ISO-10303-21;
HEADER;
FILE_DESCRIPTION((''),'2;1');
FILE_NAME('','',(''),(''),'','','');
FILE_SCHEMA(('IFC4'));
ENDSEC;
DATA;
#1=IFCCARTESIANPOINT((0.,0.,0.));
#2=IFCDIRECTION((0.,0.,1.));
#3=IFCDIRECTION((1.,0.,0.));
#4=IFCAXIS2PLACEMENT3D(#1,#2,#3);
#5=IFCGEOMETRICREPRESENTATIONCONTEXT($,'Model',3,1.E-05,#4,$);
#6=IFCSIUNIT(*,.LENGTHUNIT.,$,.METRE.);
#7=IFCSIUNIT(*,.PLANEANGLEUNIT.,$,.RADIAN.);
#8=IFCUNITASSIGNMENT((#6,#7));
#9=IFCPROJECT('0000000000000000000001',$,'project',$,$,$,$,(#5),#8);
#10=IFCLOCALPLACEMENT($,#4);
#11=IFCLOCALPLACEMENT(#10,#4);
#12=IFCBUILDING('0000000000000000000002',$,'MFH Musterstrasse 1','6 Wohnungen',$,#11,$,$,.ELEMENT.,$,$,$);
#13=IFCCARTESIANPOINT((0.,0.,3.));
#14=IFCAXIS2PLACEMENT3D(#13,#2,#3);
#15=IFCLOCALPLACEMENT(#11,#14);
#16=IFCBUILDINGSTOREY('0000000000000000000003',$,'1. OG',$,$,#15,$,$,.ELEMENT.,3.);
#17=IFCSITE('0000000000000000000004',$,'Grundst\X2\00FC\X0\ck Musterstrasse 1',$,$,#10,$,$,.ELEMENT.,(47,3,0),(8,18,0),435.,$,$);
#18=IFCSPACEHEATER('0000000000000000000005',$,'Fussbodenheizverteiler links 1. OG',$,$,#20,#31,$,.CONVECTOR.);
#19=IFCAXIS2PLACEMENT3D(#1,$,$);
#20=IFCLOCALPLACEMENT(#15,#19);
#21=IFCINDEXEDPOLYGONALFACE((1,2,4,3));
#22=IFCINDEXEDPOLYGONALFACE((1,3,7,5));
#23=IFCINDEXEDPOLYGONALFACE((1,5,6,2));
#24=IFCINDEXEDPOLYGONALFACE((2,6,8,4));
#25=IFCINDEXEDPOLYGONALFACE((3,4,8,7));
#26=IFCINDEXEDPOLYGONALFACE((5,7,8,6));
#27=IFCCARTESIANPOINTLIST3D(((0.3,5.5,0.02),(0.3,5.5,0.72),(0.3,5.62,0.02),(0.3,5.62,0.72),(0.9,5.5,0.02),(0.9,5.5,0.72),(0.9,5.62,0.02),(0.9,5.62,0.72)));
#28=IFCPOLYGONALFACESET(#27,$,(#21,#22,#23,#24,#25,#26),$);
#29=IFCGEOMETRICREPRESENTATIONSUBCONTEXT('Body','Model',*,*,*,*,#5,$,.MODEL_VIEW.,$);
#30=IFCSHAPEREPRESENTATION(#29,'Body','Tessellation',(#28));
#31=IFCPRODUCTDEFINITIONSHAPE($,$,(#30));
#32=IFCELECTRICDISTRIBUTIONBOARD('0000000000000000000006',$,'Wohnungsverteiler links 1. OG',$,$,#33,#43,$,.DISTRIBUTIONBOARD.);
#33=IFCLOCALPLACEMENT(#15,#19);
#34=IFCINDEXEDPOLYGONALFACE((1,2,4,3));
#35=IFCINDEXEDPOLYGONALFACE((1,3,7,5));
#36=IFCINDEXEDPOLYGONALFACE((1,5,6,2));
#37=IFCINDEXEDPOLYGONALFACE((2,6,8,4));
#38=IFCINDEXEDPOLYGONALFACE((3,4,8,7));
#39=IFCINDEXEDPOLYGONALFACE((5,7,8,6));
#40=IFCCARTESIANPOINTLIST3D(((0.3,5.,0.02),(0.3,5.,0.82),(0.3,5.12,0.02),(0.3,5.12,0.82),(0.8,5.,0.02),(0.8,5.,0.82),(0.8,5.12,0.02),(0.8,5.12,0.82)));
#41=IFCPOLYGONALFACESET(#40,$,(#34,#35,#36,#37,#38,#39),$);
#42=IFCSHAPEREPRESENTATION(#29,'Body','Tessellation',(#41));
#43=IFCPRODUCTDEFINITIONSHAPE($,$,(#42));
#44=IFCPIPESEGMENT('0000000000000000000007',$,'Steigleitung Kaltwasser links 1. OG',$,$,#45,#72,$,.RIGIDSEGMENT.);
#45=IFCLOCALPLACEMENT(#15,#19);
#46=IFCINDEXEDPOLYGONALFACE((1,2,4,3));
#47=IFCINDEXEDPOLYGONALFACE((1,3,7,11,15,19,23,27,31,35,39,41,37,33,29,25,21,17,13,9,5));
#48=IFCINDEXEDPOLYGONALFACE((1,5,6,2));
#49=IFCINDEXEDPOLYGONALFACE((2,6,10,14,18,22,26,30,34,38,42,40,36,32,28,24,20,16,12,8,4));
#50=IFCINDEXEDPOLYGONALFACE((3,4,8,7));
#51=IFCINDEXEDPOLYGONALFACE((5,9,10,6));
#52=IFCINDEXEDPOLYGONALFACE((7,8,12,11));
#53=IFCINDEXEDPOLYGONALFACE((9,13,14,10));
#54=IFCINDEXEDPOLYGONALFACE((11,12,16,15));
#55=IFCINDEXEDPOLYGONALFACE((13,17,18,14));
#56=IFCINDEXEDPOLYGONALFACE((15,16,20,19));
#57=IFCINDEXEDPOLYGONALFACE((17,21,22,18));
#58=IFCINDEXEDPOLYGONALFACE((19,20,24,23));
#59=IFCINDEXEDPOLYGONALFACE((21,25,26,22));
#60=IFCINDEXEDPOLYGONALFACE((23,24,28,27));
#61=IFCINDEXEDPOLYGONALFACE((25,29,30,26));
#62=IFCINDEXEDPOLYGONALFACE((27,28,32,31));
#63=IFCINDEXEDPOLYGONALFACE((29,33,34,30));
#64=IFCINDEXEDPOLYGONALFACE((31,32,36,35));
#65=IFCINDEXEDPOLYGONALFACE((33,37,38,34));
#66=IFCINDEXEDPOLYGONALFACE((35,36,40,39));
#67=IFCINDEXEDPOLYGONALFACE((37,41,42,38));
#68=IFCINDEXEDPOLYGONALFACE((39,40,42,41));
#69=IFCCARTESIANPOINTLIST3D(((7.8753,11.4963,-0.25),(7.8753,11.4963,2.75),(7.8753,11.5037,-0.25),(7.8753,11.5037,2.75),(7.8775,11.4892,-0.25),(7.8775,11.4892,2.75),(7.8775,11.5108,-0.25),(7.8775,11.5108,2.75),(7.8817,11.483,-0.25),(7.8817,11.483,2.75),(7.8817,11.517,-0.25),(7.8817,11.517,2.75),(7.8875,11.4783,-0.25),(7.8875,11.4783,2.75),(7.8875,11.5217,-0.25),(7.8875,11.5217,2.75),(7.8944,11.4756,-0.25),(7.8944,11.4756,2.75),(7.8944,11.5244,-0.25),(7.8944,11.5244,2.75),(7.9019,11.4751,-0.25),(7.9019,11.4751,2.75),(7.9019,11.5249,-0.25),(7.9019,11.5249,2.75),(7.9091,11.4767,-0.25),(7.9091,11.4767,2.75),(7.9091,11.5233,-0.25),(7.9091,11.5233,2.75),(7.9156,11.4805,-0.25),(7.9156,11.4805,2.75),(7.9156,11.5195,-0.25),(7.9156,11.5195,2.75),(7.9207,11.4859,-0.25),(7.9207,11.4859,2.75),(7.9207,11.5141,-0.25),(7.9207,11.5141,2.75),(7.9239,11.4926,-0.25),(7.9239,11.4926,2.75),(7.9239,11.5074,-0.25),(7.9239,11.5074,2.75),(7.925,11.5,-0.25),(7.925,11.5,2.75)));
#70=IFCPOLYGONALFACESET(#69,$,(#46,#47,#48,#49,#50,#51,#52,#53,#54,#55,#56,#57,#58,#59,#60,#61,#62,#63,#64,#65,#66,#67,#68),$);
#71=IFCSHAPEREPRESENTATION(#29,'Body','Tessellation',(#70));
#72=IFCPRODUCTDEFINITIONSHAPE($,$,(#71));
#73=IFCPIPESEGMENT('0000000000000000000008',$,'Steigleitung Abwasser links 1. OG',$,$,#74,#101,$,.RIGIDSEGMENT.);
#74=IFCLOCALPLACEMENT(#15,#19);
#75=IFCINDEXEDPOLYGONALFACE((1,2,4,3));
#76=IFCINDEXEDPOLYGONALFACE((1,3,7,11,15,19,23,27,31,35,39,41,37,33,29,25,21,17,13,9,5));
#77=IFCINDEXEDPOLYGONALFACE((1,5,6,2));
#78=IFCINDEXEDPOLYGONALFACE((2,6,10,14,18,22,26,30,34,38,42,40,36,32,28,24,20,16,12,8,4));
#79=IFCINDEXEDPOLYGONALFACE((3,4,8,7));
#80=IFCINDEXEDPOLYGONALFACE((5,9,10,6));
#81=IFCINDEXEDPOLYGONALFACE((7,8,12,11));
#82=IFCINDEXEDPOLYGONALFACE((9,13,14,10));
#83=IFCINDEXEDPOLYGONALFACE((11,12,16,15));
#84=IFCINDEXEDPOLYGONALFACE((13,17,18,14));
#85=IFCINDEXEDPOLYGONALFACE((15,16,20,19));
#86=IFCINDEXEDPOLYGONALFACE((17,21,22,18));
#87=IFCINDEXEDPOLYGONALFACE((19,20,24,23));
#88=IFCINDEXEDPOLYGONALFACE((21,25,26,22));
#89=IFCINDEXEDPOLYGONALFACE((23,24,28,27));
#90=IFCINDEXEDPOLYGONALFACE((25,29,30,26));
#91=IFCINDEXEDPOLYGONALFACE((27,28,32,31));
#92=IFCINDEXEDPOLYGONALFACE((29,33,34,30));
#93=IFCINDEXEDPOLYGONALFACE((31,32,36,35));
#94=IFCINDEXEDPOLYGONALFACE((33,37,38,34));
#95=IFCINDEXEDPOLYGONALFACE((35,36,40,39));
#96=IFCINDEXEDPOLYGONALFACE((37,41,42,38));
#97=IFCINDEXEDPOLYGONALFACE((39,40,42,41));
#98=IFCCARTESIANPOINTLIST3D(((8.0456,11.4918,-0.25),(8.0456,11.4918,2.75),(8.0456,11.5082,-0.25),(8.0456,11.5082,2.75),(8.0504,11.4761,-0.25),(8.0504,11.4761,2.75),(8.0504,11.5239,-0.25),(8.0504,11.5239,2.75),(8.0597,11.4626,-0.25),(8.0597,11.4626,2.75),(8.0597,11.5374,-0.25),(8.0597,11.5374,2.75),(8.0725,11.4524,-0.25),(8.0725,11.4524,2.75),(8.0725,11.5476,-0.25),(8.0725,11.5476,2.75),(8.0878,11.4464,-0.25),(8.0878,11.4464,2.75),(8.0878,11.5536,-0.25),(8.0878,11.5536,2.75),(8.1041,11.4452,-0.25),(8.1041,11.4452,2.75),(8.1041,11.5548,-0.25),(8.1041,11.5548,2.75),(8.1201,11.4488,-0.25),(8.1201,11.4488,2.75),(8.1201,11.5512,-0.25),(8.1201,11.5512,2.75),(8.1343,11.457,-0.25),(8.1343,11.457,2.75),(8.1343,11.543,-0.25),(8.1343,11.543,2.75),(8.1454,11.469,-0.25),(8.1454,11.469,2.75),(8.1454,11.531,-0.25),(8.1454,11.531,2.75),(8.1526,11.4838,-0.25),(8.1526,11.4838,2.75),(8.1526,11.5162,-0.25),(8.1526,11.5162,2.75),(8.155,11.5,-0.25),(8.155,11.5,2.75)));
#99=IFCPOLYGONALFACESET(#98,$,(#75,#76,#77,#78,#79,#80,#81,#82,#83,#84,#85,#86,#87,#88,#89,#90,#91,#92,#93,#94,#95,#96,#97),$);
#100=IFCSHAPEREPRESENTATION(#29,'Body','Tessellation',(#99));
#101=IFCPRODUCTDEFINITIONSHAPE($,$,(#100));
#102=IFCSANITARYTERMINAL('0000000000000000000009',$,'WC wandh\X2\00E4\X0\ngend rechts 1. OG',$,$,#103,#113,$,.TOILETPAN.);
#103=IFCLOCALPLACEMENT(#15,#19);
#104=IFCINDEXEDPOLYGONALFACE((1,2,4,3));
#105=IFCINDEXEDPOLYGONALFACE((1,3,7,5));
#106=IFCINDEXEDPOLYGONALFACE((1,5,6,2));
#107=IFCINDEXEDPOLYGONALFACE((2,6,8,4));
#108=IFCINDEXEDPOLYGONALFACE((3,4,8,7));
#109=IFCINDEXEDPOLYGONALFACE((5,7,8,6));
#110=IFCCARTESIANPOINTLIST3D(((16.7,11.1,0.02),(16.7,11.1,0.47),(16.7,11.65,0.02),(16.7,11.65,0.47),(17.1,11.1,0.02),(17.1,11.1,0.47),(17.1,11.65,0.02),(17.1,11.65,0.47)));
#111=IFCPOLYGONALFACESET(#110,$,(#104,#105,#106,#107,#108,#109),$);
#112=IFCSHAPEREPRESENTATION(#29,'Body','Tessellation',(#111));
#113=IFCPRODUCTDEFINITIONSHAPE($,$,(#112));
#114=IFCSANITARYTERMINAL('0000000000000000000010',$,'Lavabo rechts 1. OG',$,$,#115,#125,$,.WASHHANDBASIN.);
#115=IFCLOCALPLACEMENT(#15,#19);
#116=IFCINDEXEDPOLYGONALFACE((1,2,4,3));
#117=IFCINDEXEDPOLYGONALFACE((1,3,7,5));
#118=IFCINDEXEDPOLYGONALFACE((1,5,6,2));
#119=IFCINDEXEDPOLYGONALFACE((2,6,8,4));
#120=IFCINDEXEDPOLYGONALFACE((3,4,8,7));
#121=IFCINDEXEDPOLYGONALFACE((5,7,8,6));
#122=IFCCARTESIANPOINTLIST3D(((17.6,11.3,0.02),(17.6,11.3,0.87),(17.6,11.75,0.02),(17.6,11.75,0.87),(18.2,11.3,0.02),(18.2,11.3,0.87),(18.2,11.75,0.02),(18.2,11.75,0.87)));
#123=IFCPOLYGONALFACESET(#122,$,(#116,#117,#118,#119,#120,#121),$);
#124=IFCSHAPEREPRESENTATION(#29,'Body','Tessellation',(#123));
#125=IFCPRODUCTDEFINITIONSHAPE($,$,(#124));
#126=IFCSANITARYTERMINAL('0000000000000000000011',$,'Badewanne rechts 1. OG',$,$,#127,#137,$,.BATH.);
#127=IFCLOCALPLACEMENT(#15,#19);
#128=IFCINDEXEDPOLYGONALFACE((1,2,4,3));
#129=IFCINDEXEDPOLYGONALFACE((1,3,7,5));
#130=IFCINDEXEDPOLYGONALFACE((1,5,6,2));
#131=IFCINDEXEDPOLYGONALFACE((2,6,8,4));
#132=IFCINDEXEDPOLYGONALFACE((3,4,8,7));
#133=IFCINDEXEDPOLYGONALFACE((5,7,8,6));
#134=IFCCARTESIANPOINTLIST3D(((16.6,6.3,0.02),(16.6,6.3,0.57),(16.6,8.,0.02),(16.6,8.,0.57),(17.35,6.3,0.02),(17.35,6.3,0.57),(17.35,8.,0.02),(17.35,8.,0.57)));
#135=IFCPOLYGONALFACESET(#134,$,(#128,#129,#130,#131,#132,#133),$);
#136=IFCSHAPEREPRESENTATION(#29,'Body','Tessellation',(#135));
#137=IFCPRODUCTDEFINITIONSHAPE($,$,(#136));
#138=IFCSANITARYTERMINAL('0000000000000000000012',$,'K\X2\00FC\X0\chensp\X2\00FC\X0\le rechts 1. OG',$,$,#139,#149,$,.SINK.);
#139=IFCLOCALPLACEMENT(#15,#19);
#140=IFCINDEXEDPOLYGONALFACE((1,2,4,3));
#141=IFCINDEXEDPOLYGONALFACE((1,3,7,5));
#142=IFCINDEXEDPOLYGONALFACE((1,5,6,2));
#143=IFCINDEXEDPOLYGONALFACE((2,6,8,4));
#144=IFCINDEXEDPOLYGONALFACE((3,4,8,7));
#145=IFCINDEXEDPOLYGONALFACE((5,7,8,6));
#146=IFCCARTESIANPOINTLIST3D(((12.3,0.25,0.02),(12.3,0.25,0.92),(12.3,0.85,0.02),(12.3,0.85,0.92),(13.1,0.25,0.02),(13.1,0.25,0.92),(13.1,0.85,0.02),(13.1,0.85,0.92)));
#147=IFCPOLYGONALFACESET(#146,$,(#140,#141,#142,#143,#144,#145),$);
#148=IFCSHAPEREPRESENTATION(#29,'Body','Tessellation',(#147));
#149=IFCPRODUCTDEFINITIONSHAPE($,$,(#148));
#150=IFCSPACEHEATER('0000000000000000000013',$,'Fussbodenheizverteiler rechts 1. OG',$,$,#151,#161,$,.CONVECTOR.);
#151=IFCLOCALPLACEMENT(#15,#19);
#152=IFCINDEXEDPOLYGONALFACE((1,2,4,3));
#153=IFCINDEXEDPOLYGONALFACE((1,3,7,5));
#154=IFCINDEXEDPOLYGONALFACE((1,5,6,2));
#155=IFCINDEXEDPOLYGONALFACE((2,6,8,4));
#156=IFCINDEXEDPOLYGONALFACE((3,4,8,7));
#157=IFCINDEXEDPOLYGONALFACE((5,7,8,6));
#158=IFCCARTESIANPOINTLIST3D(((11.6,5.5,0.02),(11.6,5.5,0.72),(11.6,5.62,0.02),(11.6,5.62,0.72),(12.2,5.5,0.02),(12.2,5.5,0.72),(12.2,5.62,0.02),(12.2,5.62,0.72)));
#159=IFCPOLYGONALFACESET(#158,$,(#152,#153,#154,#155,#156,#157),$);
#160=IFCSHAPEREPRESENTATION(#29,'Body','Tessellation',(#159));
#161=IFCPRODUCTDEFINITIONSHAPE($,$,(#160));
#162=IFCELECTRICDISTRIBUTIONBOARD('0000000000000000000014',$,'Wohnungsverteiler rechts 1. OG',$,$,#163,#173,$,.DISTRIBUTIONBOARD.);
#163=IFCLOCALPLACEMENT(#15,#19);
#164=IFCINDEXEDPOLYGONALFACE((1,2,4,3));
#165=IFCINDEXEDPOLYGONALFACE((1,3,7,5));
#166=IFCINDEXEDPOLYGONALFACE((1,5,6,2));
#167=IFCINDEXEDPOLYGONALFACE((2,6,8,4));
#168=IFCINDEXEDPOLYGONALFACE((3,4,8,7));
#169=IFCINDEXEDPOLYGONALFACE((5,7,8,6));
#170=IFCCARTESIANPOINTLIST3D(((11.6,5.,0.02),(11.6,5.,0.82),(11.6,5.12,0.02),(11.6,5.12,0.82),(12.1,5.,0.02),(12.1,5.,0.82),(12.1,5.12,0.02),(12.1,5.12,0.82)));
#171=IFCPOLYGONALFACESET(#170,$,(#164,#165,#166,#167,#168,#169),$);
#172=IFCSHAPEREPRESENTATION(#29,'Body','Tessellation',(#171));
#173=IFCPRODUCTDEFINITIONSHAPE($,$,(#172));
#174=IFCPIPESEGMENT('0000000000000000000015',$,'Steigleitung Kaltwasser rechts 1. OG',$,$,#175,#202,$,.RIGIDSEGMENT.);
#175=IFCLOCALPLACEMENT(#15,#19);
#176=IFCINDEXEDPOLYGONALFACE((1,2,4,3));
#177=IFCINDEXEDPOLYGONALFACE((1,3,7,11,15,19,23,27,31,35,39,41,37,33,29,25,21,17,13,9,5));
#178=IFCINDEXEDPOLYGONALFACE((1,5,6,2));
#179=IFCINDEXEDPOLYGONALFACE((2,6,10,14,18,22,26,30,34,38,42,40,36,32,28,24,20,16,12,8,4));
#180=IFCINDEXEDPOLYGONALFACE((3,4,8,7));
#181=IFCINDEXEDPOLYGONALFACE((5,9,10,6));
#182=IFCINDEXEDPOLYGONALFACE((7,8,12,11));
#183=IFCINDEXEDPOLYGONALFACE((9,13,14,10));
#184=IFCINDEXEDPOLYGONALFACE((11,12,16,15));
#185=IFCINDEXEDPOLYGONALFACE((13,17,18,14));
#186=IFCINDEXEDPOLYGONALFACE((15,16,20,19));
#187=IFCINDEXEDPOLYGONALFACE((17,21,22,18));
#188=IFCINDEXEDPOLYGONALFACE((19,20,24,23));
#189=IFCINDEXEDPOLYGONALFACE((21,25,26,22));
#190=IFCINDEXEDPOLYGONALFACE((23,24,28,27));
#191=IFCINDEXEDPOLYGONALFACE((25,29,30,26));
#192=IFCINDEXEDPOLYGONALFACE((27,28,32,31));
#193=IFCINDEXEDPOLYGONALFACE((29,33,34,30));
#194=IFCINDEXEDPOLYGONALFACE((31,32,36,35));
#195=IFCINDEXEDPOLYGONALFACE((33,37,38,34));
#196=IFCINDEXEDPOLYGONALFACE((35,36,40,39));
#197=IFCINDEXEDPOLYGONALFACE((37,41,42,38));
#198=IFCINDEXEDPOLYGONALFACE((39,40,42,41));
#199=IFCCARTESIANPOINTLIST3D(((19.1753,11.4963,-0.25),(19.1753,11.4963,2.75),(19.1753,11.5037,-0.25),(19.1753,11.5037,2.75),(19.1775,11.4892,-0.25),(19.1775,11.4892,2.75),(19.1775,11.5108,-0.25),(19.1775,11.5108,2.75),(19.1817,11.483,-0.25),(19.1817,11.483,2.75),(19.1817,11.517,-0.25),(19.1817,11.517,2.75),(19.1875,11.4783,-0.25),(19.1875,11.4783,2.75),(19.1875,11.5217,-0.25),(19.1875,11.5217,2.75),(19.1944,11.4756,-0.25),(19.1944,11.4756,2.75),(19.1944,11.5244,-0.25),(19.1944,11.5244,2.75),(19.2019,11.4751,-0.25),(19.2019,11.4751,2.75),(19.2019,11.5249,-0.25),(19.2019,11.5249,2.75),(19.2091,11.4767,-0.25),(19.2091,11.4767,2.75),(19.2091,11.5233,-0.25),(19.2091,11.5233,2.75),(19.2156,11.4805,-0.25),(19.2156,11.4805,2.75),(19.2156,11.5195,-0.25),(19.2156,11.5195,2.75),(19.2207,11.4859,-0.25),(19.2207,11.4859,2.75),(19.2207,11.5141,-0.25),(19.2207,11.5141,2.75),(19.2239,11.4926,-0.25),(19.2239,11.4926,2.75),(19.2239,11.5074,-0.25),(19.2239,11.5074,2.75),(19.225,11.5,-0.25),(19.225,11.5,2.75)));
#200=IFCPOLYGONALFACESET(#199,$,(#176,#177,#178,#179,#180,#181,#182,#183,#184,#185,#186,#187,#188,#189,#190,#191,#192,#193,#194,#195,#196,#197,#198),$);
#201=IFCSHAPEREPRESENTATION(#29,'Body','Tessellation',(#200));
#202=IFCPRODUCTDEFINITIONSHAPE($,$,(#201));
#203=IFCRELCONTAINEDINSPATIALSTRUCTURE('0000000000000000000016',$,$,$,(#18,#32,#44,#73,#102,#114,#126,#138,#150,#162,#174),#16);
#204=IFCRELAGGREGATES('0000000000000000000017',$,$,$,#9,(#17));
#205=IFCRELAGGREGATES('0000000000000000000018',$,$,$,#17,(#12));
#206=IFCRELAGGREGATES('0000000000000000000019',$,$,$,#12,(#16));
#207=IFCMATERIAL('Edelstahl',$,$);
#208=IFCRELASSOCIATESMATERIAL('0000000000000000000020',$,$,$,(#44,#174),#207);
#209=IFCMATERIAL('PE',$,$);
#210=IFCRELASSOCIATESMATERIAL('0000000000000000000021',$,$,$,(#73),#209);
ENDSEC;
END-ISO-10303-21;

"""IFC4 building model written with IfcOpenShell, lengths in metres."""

from ifc_helpers import new_model, si_unit, frame, frame_2d, origin_with_axes, origin_2d_with_axis, place, context, subcontext, project, spatial, rectangle, circle, extrude, material, element, save


model = new_model("IFC4")

# Units and contexts
model_context = context("Model", 3, precision=1e-05, world=origin_with_axes())
body_context = subcontext(model_context, "Body", "Model", "MODEL_VIEW")
ifc_project = project(units=[si_unit("LENGTHUNIT", "METRE"), si_unit("PLANEANGLEUNIT", "RADIAN")], contexts=[model_context])

# Site, building, storey
site_placement = place(None, origin_with_axes())
site = spatial("IfcSite", under=ifc_project, at=site_placement, Name="Grundstück Musterstrasse 1", CompositionType="ELEMENT", RefLatitude=(47, 3, 0), RefLongitude=(8, 18, 0), RefElevation=435.0)
building_placement = place(site_placement, origin_with_axes())
building = spatial("IfcBuilding", under=site, at=building_placement, Name="MFH Musterstrasse 1", Description="6 Wohnungen", CompositionType="ELEMENT")
storey_placement = place(building_placement, frame((0.0, 0.0, 3.0), z_axis=(0.0, 0.0, 1.0), x_axis=(1.0, 0.0, 0.0)))
storey = spatial("IfcBuildingStorey", under=building, at=storey_placement, Name="1. OG", CompositionType="ELEMENT", Elevation=3.0)

# Space heater
space_heater_1_placement = place(storey_placement, origin_with_axes())
element("IfcSpaceHeater", 1, at=space_heater_1_placement, inside=storey, Name="Fussbodenheizverteiler links 1. OG", PredefinedType="CONVECTOR", context=body_context, shape_type="SweptSolid", body=[
    extrude(rectangle(XDim=0.6, YDim=0.12, at=frame_2d((0.3, 0.06), x_axis=(1.0, 0.0))), frame((0.3, 5.5, 0.02), z_axis=(0.0, 0.0, 1.0), x_axis=(1.0, 0.0, 0.0)), (0.0, 0.0, 1.0), 0.7),
])

# Electric distribution board
electric_distribution_board_1_placement = place(storey_placement, origin_with_axes())
element("IfcElectricDistributionBoard", 2, at=electric_distribution_board_1_placement, inside=storey, Name="Wohnungsverteiler links 1. OG", PredefinedType="DISTRIBUTIONBOARD", context=body_context, shape_type="SweptSolid", body=[
    extrude(rectangle(XDim=0.5, YDim=0.12, at=frame_2d((0.25, 0.06), x_axis=(1.0, 0.0))), frame((0.3, 5.0, 0.02), z_axis=(0.0, 0.0, 1.0), x_axis=(1.0, 0.0, 0.0)), (0.0, 0.0, 1.0), 0.8),
])

# Pipe segments
ifc_material_1 = material(Name="Edelstahl")
pipe_segment_1_placement = place(storey_placement, origin_with_axes())
element("IfcPipeSegment", 3, at=pipe_segment_1_placement, inside=storey, material=ifc_material_1, Name="Steigleitung Kaltwasser links 1. OG", PredefinedType="RIGIDSEGMENT", context=body_context, shape_type="SweptSolid", body=[
    extrude(circle(Radius=0.025, at=origin_2d_with_axis()), frame((7.9, 11.5, -0.25), z_axis=(0.0, 0.0, 1.0), x_axis=(1.0, 0.0, 0.0)), (0.0, 0.0, 1.0), 3.0),
])
ifc_material_2 = material(Name="PE")
pipe_segment_2_placement = place(storey_placement, origin_with_axes())
element("IfcPipeSegment", 4, at=pipe_segment_2_placement, inside=storey, material=ifc_material_2, Name="Steigleitung Abwasser links 1. OG", PredefinedType="RIGIDSEGMENT", context=body_context, shape_type="SweptSolid", body=[
    extrude(circle(Radius=0.055, at=origin_2d_with_axis()), frame((8.1, 11.5, -0.25), z_axis=(0.0, 0.0, 1.0), x_axis=(1.0, 0.0, 0.0)), (0.0, 0.0, 1.0), 3.0),
])

# Sanitary terminals
sanitary_terminal_1_placement = place(storey_placement, origin_with_axes())
element("IfcSanitaryTerminal", 5, at=sanitary_terminal_1_placement, inside=storey, Name="WC wandhängend rechts 1. OG", PredefinedType="TOILETPAN", context=body_context, shape_type="SweptSolid", body=[
    extrude(rectangle(XDim=0.4, YDim=0.55, at=frame_2d((0.2, 0.275), x_axis=(1.0, 0.0))), frame((16.7, 11.1, 0.02), z_axis=(0.0, 0.0, 1.0), x_axis=(1.0, 0.0, 0.0)), (0.0, 0.0, 1.0), 0.45),
])
sanitary_terminal_2_placement = place(storey_placement, origin_with_axes())
element("IfcSanitaryTerminal", 6, at=sanitary_terminal_2_placement, inside=storey, Name="Lavabo rechts 1. OG", PredefinedType="WASHHANDBASIN", context=body_context, shape_type="SweptSolid", body=[
    extrude(rectangle(XDim=0.6, YDim=0.45, at=frame_2d((0.3, 0.225), x_axis=(1.0, 0.0))), frame((17.6, 11.3, 0.02), z_axis=(0.0, 0.0, 1.0), x_axis=(1.0, 0.0, 0.0)), (0.0, 0.0, 1.0), 0.85),
])
sanitary_terminal_3_placement = place(storey_placement, origin_with_axes())
element("IfcSanitaryTerminal", 7, at=sanitary_terminal_3_placement, inside=storey, Name="Badewanne rechts 1. OG", PredefinedType="BATH", context=body_context, shape_type="SweptSolid", body=[
    extrude(rectangle(XDim=0.75, YDim=1.7, at=frame_2d((0.375, 0.85), x_axis=(1.0, 0.0))), frame((16.6, 6.3, 0.02), z_axis=(0.0, 0.0, 1.0), x_axis=(1.0, 0.0, 0.0)), (0.0, 0.0, 1.0), 0.55),
])
sanitary_terminal_4_placement = place(storey_placement, origin_with_axes())
element("IfcSanitaryTerminal", 8, at=sanitary_terminal_4_placement, inside=storey, Name="Küchenspüle rechts 1. OG", PredefinedType="SINK", context=body_context, shape_type="SweptSolid", body=[
    extrude(rectangle(XDim=0.8, YDim=0.6, at=frame_2d((0.4, 0.3), x_axis=(1.0, 0.0))), frame((12.3, 0.25, 0.02), z_axis=(0.0, 0.0, 1.0), x_axis=(1.0, 0.0, 0.0)), (0.0, 0.0, 1.0), 0.9),
])

# Space heater
space_heater_2_placement = place(storey_placement, origin_with_axes())
element("IfcSpaceHeater", 9, at=space_heater_2_placement, inside=storey, Name="Fussbodenheizverteiler rechts 1. OG", PredefinedType="CONVECTOR", context=body_context, shape_type="SweptSolid", body=[
    extrude(rectangle(XDim=0.6, YDim=0.12, at=frame_2d((0.3, 0.06), x_axis=(1.0, 0.0))), frame((11.6, 5.5, 0.02), z_axis=(0.0, 0.0, 1.0), x_axis=(1.0, 0.0, 0.0)), (0.0, 0.0, 1.0), 0.7),
])

# Electric distribution board
electric_distribution_board_2_placement = place(storey_placement, origin_with_axes())
element("IfcElectricDistributionBoard", 10, at=electric_distribution_board_2_placement, inside=storey, Name="Wohnungsverteiler rechts 1. OG", PredefinedType="DISTRIBUTIONBOARD", context=body_context, shape_type="SweptSolid", body=[
    extrude(rectangle(XDim=0.5, YDim=0.12, at=frame_2d((0.25, 0.06), x_axis=(1.0, 0.0))), frame((11.6, 5.0, 0.02), z_axis=(0.0, 0.0, 1.0), x_axis=(1.0, 0.0, 0.0)), (0.0, 0.0, 1.0), 0.8),
])

# Pipe segment
pipe_segment_3_placement = place(storey_placement, origin_with_axes())
element("IfcPipeSegment", 11, at=pipe_segment_3_placement, inside=storey, material=ifc_material_1, Name="Steigleitung Kaltwasser rechts 1. OG", PredefinedType="RIGIDSEGMENT", context=body_context, shape_type="SweptSolid", body=[
    extrude(circle(Radius=0.025, at=origin_2d_with_axis()), frame((19.2, 11.5, -0.25), z_axis=(0.0, 0.0, 1.0), x_axis=(1.0, 0.0, 0.0)), (0.0, 0.0, 1.0), 3.0),
])

save(model, "model.ifc")
